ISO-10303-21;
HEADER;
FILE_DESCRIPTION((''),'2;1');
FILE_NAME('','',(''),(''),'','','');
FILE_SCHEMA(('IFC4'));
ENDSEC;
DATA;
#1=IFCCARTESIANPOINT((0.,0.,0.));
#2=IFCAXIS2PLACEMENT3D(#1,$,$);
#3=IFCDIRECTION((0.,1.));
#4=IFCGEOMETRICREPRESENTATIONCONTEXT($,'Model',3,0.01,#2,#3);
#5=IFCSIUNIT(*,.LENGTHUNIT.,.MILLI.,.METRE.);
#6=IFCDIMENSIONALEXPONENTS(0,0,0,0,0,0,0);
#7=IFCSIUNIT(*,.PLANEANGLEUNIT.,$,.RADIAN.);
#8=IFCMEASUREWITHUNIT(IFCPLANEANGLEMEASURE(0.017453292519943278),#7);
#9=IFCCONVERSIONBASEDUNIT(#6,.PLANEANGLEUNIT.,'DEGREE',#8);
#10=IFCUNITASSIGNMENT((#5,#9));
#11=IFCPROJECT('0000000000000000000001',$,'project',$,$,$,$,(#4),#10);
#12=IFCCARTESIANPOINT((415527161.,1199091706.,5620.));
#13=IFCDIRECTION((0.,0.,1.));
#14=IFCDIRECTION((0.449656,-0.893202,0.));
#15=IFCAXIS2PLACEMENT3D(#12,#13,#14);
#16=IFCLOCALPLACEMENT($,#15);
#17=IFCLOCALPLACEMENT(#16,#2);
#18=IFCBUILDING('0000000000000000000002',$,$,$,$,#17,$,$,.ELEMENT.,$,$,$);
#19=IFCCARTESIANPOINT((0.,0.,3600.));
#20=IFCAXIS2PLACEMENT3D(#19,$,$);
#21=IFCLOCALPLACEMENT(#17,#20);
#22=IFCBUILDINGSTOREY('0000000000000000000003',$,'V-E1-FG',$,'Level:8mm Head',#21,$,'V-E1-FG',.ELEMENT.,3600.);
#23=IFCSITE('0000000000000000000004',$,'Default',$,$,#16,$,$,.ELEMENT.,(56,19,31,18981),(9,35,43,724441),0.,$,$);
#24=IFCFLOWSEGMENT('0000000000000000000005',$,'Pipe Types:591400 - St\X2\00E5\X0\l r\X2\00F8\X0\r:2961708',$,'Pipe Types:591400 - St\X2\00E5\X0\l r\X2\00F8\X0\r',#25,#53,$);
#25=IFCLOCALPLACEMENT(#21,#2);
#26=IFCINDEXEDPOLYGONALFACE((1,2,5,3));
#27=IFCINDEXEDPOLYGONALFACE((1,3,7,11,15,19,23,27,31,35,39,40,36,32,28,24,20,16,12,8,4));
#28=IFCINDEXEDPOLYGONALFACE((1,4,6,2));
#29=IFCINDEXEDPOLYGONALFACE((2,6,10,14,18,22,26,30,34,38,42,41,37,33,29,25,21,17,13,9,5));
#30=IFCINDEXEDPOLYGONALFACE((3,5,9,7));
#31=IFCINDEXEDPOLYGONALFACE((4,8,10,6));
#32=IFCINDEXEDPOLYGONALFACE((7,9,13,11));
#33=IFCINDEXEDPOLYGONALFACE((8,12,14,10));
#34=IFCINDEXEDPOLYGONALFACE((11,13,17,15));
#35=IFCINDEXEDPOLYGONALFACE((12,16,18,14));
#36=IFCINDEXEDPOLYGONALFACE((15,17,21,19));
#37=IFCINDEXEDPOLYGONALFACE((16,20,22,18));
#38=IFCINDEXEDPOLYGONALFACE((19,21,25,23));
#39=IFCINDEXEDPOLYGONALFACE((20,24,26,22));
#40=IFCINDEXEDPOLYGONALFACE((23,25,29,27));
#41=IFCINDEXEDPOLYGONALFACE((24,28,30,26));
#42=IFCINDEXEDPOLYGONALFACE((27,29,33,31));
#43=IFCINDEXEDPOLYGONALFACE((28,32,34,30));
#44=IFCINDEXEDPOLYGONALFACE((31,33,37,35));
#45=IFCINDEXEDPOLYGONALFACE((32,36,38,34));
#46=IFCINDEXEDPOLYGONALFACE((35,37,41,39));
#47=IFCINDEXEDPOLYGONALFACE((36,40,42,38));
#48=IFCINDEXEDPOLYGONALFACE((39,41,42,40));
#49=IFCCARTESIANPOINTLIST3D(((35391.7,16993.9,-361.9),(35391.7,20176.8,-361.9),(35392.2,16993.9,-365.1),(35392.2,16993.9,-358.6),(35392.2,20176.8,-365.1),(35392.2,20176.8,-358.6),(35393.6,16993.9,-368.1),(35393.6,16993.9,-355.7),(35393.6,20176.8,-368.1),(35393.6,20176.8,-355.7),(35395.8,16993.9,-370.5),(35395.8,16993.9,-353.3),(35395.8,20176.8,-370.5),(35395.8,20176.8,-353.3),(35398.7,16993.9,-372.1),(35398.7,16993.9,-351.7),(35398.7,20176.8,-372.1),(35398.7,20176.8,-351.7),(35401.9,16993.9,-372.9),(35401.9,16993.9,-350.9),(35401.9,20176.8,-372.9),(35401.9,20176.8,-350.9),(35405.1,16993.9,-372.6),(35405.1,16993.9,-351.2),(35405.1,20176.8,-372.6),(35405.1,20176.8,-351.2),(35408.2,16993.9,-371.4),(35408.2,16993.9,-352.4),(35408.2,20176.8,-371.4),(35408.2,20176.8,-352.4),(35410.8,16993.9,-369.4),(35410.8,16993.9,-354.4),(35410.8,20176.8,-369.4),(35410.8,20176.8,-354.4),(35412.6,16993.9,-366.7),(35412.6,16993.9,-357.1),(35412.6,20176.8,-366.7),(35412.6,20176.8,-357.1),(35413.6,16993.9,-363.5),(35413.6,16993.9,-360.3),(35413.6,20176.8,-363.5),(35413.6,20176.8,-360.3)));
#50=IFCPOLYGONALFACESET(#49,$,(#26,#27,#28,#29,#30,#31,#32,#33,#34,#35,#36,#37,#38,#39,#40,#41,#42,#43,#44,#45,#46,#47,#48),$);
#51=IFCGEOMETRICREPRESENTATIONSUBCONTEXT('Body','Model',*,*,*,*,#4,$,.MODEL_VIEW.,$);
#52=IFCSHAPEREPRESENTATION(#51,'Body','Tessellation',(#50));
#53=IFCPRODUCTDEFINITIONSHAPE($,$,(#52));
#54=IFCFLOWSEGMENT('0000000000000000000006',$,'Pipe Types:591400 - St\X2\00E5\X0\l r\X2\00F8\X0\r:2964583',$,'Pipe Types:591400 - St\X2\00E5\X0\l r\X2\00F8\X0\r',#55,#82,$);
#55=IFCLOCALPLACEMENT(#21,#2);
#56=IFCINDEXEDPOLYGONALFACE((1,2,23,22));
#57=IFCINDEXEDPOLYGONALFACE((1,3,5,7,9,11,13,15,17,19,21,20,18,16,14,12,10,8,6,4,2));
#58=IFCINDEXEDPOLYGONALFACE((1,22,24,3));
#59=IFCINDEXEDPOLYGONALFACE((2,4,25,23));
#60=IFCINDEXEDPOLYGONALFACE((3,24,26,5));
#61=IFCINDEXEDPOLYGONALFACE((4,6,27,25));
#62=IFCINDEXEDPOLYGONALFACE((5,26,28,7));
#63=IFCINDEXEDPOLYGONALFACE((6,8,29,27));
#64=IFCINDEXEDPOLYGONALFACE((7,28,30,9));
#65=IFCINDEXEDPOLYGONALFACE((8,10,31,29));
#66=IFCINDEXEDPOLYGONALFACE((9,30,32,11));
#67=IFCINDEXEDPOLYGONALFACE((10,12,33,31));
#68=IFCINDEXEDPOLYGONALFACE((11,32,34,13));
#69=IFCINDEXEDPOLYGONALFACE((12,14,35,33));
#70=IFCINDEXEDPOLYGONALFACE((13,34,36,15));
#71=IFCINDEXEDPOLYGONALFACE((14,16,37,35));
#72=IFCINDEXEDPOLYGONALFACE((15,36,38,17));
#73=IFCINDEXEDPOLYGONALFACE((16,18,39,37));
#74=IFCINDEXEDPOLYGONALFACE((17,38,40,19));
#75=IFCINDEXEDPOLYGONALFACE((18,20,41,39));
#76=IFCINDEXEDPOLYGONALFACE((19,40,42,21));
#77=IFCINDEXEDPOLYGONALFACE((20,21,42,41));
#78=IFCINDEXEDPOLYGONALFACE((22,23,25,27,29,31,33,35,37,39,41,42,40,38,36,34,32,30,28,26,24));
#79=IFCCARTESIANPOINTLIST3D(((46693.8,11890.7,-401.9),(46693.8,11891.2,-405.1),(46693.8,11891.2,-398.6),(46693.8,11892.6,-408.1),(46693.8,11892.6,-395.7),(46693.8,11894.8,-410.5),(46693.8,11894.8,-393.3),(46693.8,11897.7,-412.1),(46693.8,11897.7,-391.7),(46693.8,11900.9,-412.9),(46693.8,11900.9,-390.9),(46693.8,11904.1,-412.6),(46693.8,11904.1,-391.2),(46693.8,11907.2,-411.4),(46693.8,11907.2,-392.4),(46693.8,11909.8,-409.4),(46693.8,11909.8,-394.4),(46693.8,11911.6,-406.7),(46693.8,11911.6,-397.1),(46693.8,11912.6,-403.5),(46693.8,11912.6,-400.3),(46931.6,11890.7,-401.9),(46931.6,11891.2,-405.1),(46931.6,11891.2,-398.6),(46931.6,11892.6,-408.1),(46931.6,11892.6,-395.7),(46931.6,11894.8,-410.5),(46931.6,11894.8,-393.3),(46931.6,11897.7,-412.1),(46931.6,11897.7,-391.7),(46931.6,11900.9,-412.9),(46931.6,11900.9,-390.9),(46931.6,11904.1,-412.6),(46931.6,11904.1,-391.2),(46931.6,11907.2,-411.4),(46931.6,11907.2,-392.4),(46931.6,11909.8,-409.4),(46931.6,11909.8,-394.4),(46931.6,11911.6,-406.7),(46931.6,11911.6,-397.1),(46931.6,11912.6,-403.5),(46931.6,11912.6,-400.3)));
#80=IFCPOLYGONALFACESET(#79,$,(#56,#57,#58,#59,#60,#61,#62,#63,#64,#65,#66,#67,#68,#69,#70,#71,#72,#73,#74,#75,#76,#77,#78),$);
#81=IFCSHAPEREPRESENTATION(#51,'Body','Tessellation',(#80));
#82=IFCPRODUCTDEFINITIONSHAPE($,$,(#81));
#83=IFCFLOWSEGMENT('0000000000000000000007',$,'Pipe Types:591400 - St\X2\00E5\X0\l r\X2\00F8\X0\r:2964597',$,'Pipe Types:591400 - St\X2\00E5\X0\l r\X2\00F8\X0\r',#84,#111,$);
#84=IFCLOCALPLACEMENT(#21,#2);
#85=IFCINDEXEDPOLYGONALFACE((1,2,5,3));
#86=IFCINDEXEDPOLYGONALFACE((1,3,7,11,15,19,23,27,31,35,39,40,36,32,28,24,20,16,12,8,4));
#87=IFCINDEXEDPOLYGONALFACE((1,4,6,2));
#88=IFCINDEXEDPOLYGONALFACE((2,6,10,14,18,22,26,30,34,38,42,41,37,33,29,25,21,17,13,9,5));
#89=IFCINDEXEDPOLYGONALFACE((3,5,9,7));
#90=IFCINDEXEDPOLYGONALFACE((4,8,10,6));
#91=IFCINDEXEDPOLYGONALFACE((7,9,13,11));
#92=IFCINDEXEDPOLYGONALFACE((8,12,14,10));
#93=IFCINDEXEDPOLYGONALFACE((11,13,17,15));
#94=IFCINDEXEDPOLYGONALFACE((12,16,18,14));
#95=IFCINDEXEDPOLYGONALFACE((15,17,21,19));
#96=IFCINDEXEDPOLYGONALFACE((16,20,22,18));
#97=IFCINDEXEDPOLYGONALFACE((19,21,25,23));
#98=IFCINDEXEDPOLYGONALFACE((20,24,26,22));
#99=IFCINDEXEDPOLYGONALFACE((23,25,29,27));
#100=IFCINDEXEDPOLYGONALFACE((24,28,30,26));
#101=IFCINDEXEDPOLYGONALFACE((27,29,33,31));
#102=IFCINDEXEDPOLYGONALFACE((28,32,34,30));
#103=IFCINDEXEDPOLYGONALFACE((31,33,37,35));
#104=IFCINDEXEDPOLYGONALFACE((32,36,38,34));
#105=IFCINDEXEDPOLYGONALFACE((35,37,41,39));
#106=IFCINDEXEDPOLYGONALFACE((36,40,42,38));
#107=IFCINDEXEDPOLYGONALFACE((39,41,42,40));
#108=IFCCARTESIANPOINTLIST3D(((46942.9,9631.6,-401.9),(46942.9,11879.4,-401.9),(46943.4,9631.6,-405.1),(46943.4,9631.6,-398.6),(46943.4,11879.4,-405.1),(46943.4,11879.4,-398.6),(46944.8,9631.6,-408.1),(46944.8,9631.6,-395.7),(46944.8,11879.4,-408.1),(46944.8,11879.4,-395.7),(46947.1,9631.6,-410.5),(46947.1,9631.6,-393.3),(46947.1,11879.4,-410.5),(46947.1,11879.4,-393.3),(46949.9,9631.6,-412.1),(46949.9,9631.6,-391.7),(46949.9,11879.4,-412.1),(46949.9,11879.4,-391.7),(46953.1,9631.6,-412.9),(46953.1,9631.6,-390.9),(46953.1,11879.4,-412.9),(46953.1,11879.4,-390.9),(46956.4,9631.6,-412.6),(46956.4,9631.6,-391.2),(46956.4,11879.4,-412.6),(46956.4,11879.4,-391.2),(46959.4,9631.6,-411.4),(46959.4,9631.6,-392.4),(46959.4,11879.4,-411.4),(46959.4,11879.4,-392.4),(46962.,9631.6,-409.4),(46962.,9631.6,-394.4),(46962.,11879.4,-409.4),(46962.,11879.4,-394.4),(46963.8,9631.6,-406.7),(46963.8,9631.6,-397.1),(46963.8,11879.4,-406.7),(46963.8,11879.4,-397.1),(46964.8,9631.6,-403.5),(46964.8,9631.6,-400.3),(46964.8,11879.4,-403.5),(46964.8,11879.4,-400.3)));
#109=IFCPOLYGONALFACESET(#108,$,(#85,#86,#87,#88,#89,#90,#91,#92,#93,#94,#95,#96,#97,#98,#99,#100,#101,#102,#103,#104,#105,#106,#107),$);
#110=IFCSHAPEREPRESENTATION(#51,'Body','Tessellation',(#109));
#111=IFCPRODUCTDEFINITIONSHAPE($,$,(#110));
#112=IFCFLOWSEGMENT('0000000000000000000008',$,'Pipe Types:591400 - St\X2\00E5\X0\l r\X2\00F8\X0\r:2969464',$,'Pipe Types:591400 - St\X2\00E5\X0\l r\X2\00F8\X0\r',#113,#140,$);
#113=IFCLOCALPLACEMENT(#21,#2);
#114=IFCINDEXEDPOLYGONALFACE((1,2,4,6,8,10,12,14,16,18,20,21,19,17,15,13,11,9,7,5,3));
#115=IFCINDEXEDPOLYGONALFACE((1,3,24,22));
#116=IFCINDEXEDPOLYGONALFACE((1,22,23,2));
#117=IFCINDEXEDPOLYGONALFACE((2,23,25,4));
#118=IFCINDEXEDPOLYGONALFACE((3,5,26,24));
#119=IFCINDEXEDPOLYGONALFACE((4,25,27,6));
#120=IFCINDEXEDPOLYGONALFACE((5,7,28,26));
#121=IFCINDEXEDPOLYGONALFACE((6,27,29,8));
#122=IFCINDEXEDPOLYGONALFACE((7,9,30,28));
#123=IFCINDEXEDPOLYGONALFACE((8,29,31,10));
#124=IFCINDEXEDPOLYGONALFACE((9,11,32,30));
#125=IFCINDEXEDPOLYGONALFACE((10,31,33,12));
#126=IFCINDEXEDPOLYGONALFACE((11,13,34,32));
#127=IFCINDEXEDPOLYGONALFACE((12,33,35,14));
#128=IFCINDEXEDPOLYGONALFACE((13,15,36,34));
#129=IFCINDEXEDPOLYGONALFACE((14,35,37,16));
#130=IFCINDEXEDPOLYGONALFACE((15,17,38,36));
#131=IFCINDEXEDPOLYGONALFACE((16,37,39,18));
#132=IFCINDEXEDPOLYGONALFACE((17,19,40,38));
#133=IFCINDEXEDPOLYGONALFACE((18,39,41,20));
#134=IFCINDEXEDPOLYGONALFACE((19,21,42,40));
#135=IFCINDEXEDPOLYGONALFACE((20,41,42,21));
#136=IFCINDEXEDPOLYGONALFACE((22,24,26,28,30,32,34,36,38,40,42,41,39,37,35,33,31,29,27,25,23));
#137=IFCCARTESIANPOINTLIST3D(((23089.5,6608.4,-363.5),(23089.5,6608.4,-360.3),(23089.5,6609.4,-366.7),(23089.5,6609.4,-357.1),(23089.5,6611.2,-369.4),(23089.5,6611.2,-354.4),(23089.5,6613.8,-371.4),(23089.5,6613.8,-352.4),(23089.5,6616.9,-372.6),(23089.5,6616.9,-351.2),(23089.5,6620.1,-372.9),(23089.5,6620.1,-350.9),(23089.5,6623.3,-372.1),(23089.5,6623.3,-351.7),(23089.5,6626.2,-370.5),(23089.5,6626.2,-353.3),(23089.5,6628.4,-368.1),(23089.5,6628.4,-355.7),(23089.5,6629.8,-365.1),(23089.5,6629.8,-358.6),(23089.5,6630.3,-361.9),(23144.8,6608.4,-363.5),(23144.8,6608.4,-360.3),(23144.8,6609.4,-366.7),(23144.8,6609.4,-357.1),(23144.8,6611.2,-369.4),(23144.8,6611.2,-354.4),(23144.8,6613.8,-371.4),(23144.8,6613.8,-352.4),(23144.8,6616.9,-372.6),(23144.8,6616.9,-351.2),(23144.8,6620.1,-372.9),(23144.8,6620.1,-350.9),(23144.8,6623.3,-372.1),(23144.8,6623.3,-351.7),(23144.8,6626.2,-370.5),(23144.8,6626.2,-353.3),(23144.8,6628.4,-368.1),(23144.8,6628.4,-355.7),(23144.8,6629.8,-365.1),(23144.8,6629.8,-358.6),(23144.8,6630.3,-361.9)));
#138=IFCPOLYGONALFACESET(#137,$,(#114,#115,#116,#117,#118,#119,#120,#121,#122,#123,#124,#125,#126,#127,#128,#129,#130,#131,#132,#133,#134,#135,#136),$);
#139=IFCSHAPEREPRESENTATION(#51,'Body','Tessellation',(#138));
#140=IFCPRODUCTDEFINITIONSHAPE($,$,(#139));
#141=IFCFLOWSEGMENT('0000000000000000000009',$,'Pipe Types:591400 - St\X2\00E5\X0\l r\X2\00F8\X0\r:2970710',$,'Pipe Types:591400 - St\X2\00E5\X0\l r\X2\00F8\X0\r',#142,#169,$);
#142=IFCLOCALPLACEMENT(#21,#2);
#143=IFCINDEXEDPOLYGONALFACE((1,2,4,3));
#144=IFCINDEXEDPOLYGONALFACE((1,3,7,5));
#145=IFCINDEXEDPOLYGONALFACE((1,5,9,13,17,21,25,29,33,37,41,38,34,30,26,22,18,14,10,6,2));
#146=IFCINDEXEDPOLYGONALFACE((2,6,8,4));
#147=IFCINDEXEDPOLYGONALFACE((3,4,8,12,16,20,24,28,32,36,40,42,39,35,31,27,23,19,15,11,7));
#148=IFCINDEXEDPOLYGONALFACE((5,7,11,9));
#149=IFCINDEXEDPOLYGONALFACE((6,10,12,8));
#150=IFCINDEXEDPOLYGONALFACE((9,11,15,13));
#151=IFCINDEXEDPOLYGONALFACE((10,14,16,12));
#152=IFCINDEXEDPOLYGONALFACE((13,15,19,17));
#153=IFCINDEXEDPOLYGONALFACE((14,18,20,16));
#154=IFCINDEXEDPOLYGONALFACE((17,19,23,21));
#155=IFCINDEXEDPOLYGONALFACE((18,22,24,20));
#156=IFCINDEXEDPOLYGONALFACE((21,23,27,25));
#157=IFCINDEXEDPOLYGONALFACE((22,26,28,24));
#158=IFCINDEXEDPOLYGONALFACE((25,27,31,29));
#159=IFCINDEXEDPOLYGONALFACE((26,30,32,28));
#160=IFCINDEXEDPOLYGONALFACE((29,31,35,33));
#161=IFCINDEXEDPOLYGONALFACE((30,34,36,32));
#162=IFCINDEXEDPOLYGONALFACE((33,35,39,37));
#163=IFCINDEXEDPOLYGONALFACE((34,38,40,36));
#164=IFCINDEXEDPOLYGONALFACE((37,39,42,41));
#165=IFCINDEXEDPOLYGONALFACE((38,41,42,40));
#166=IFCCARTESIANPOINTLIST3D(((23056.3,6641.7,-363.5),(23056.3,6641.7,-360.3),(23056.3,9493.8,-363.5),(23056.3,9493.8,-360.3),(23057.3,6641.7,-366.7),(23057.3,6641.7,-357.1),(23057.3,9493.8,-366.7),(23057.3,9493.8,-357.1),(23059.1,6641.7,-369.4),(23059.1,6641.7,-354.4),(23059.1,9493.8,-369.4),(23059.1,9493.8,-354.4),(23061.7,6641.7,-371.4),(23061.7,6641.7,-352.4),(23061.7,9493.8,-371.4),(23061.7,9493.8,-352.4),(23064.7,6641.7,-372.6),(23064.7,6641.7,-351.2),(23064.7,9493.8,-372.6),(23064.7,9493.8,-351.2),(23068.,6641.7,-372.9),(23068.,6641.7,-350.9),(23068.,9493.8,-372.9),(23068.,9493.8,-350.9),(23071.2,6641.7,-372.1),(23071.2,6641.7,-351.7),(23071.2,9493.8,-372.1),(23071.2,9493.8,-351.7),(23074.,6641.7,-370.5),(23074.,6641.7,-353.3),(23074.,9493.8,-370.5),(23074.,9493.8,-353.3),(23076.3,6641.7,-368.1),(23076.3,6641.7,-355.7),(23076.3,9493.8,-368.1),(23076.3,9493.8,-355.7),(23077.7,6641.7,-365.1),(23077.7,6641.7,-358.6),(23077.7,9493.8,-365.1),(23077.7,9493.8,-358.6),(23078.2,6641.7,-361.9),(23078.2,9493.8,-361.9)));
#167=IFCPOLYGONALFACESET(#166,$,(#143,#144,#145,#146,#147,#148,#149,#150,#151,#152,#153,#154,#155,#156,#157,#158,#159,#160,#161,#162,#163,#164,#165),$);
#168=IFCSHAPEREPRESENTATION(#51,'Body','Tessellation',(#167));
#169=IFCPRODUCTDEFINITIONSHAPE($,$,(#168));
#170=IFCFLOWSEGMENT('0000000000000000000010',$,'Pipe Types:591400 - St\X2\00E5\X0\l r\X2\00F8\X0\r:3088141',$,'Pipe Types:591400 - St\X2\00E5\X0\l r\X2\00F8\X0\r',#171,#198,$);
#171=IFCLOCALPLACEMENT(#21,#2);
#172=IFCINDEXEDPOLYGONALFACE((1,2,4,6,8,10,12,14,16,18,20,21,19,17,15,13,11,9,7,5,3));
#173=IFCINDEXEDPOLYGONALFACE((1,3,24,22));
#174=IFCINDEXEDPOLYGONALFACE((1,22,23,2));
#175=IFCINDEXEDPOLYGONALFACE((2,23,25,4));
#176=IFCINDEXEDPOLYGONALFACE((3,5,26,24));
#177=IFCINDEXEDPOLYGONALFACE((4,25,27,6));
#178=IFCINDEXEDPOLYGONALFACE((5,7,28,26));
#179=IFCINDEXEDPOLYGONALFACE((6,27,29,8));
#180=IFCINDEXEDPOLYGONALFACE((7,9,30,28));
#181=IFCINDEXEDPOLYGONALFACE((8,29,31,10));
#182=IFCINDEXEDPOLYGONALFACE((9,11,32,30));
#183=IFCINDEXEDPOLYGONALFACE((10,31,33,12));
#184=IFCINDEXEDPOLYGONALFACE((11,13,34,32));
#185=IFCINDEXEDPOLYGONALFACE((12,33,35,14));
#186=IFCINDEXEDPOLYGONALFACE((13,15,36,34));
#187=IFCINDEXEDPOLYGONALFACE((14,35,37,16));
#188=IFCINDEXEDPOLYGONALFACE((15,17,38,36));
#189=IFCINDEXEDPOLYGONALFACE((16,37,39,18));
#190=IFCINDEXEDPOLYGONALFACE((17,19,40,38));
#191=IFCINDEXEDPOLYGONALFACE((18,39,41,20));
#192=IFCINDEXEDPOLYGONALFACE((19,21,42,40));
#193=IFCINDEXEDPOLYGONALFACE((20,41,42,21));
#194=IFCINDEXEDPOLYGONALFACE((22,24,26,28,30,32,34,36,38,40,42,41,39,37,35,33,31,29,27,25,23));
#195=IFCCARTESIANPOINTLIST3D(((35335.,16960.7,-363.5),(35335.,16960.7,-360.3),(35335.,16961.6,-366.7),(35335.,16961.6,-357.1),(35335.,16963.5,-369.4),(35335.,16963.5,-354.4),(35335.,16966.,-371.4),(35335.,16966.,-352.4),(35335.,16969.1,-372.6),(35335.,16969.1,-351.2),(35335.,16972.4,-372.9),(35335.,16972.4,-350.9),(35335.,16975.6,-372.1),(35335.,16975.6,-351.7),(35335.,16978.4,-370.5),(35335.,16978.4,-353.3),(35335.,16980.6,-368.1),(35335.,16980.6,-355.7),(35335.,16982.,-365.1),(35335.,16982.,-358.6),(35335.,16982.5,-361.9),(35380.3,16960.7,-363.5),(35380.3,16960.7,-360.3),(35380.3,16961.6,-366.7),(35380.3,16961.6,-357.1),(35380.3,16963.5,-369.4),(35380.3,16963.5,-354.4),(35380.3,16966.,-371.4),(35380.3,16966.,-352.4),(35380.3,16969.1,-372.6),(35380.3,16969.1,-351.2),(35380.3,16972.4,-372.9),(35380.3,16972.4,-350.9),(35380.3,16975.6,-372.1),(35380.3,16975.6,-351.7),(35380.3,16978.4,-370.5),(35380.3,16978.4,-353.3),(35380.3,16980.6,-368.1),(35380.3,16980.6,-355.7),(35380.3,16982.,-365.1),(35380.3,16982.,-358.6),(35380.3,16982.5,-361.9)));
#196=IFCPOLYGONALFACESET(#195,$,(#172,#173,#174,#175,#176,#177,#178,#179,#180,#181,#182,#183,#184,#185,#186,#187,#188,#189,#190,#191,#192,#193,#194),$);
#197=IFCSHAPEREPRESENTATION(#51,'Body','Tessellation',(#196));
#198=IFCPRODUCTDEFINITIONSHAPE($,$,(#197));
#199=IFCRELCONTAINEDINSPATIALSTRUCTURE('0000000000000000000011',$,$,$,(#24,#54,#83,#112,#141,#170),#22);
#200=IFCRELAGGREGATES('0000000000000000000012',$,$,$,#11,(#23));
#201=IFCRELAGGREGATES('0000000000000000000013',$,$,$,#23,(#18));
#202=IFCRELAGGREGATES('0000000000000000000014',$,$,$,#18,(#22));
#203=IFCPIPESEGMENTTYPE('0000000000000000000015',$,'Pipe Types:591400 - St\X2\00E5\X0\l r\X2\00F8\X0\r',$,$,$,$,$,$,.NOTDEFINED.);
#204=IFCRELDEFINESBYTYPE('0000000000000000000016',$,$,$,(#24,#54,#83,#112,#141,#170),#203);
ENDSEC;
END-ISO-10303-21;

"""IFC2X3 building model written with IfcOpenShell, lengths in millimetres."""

from ifc_helpers import new_model, entity, si_unit, converted_unit, direction, frame, frame_2d, origin, origin_2d_with_axis, place, context, subcontext, project, spatial, circle, extrude, type_object, element, save


model = new_model("IFC2X3")

# Units and contexts
model_context = context("Model", 3, precision=0.01, world=origin(), true_north=direction((0.0, 1.0)))
body_context = subcontext(model_context, "Body", "Model", "MODEL_VIEW")
ifc_project = project(units=[si_unit("LENGTHUNIT", "METRE", prefix="MILLI"), converted_unit("PLANEANGLEUNIT", "DEGREE", entity("IfcPlaneAngleMeasure", 0.017453292519943278), si_unit("PLANEANGLEUNIT", "RADIAN"), dimensions=[0, 0, 0, 0, 0, 0, 0])], contexts=[model_context])

# Site, building, storey
site_placement = place(None, frame((415527161.0, 1199091706.0, 5620.0), z_axis=(0.0, 0.0, 1.0), x_axis=(0.449656, -0.893202, 0.0)))
site = spatial("IfcSite", under=ifc_project, at=site_placement, Name="Default", CompositionType="ELEMENT", RefLatitude=(56, 19, 31, 18981), RefLongitude=(9, 35, 43, 724441), RefElevation=0.0)
building_placement = place(site_placement, origin())
building = spatial("IfcBuilding", under=site, at=building_placement, CompositionType="ELEMENT")
storey_placement = place(building_placement, frame((0.0, 0.0, 3600.0)))
storey = spatial("IfcBuildingStorey", under=building, at=storey_placement, Name="V-E1-FG", ObjectType="Level:8mm Head", LongName="V-E1-FG", CompositionType="ELEMENT", Elevation=3600.0)

# Flow segments
pipe_segment_type_1 = type_object("IfcPipeSegmentType", Name="Pipe Types:591400 - Stål rør", PredefinedType="NOTDEFINED")
flow_segment_1_placement = place(storey_placement, origin())
element("IfcFlowSegment", 1, at=flow_segment_1_placement, inside=storey, type_object=pipe_segment_type_1, Name="Pipe Types:591400 - Stål rør:2961708", ObjectType="Pipe Types:591400 - Stål rør", context=body_context, shape_type="SweptSolid", body=[
    extrude(circle(Radius=11.0, at=frame_2d((0.0, 0.0), x_axis=(1.0, 0.0))), frame((35402.7, 16993.9, -361.9), z_axis=(0.0, 1.0, 0.0), x_axis=(-1.0, 0.0, 0.0)), (0.0, 0.0, 1.0), 3183.0),
])
flow_segment_2_placement = place(storey_placement, origin())
element("IfcFlowSegment", 2, at=flow_segment_2_placement, inside=storey, type_object=pipe_segment_type_1, Name="Pipe Types:591400 - Stål rør:2964583", ObjectType="Pipe Types:591400 - Stål rør", context=body_context, shape_type="SweptSolid", body=[
    extrude(circle(Radius=11.0, at=origin_2d_with_axis()), frame((46693.8, 11901.7, -401.9), z_axis=(1.0, 0.0, 0.0), x_axis=(0.0, -1.0, 0.0)), (0.0, 0.0, 1.0), 237.8),
])
flow_segment_3_placement = place(storey_placement, origin())
element("IfcFlowSegment", 3, at=flow_segment_3_placement, inside=storey, type_object=pipe_segment_type_1, Name="Pipe Types:591400 - Stål rør:2964597", ObjectType="Pipe Types:591400 - Stål rør", context=body_context, shape_type="SweptSolid", body=[
    extrude(circle(Radius=11.0, at=origin_2d_with_axis()), frame((46953.9, 9631.6, -401.9), z_axis=(0.0, 1.0, 0.0), x_axis=(-1.0, 0.0, 0.0)), (0.0, 0.0, 1.0), 2247.8),
])
flow_segment_4_placement = place(storey_placement, origin())
element("IfcFlowSegment", 4, at=flow_segment_4_placement, inside=storey, type_object=pipe_segment_type_1, Name="Pipe Types:591400 - Stål rør:2969464", ObjectType="Pipe Types:591400 - Stål rør", context=body_context, shape_type="SweptSolid", body=[
    extrude(circle(Radius=11.0, at=frame_2d((0.0, 0.0), x_axis=(1.0, 0.0))), frame((23089.5, 6619.3, -361.9), z_axis=(1.0, 0.0, 0.0), x_axis=(0.0, 1.0, 0.0)), (0.0, 0.0, 1.0), 55.3),
])
flow_segment_5_placement = place(storey_placement, origin())
element("IfcFlowSegment", 5, at=flow_segment_5_placement, inside=storey, type_object=pipe_segment_type_1, Name="Pipe Types:591400 - Stål rør:2970710", ObjectType="Pipe Types:591400 - Stål rør", context=body_context, shape_type="SweptSolid", body=[
    extrude(circle(Radius=11.0, at=origin_2d_with_axis()), frame((23067.2, 6641.7, -361.9), z_axis=(0.0, 1.0, 0.0), x_axis=(1.0, 0.0, 0.0)), (0.0, 0.0, 1.0), 2852.2),
])
flow_segment_6_placement = place(storey_placement, origin())
element("IfcFlowSegment", 6, at=flow_segment_6_placement, inside=storey, type_object=pipe_segment_type_1, Name="Pipe Types:591400 - Stål rør:3088141", ObjectType="Pipe Types:591400 - Stål rør", context=body_context, shape_type="SweptSolid", body=[
    extrude(circle(Radius=11.0, at=origin_2d_with_axis()), frame((35335.0, 16971.5, -361.9), z_axis=(1.0, 0.0, 0.0), x_axis=(0.0, 1.0, 0.0)), (0.0, 0.0, 1.0), 45.3),
])

save(model, "model.ifc")
